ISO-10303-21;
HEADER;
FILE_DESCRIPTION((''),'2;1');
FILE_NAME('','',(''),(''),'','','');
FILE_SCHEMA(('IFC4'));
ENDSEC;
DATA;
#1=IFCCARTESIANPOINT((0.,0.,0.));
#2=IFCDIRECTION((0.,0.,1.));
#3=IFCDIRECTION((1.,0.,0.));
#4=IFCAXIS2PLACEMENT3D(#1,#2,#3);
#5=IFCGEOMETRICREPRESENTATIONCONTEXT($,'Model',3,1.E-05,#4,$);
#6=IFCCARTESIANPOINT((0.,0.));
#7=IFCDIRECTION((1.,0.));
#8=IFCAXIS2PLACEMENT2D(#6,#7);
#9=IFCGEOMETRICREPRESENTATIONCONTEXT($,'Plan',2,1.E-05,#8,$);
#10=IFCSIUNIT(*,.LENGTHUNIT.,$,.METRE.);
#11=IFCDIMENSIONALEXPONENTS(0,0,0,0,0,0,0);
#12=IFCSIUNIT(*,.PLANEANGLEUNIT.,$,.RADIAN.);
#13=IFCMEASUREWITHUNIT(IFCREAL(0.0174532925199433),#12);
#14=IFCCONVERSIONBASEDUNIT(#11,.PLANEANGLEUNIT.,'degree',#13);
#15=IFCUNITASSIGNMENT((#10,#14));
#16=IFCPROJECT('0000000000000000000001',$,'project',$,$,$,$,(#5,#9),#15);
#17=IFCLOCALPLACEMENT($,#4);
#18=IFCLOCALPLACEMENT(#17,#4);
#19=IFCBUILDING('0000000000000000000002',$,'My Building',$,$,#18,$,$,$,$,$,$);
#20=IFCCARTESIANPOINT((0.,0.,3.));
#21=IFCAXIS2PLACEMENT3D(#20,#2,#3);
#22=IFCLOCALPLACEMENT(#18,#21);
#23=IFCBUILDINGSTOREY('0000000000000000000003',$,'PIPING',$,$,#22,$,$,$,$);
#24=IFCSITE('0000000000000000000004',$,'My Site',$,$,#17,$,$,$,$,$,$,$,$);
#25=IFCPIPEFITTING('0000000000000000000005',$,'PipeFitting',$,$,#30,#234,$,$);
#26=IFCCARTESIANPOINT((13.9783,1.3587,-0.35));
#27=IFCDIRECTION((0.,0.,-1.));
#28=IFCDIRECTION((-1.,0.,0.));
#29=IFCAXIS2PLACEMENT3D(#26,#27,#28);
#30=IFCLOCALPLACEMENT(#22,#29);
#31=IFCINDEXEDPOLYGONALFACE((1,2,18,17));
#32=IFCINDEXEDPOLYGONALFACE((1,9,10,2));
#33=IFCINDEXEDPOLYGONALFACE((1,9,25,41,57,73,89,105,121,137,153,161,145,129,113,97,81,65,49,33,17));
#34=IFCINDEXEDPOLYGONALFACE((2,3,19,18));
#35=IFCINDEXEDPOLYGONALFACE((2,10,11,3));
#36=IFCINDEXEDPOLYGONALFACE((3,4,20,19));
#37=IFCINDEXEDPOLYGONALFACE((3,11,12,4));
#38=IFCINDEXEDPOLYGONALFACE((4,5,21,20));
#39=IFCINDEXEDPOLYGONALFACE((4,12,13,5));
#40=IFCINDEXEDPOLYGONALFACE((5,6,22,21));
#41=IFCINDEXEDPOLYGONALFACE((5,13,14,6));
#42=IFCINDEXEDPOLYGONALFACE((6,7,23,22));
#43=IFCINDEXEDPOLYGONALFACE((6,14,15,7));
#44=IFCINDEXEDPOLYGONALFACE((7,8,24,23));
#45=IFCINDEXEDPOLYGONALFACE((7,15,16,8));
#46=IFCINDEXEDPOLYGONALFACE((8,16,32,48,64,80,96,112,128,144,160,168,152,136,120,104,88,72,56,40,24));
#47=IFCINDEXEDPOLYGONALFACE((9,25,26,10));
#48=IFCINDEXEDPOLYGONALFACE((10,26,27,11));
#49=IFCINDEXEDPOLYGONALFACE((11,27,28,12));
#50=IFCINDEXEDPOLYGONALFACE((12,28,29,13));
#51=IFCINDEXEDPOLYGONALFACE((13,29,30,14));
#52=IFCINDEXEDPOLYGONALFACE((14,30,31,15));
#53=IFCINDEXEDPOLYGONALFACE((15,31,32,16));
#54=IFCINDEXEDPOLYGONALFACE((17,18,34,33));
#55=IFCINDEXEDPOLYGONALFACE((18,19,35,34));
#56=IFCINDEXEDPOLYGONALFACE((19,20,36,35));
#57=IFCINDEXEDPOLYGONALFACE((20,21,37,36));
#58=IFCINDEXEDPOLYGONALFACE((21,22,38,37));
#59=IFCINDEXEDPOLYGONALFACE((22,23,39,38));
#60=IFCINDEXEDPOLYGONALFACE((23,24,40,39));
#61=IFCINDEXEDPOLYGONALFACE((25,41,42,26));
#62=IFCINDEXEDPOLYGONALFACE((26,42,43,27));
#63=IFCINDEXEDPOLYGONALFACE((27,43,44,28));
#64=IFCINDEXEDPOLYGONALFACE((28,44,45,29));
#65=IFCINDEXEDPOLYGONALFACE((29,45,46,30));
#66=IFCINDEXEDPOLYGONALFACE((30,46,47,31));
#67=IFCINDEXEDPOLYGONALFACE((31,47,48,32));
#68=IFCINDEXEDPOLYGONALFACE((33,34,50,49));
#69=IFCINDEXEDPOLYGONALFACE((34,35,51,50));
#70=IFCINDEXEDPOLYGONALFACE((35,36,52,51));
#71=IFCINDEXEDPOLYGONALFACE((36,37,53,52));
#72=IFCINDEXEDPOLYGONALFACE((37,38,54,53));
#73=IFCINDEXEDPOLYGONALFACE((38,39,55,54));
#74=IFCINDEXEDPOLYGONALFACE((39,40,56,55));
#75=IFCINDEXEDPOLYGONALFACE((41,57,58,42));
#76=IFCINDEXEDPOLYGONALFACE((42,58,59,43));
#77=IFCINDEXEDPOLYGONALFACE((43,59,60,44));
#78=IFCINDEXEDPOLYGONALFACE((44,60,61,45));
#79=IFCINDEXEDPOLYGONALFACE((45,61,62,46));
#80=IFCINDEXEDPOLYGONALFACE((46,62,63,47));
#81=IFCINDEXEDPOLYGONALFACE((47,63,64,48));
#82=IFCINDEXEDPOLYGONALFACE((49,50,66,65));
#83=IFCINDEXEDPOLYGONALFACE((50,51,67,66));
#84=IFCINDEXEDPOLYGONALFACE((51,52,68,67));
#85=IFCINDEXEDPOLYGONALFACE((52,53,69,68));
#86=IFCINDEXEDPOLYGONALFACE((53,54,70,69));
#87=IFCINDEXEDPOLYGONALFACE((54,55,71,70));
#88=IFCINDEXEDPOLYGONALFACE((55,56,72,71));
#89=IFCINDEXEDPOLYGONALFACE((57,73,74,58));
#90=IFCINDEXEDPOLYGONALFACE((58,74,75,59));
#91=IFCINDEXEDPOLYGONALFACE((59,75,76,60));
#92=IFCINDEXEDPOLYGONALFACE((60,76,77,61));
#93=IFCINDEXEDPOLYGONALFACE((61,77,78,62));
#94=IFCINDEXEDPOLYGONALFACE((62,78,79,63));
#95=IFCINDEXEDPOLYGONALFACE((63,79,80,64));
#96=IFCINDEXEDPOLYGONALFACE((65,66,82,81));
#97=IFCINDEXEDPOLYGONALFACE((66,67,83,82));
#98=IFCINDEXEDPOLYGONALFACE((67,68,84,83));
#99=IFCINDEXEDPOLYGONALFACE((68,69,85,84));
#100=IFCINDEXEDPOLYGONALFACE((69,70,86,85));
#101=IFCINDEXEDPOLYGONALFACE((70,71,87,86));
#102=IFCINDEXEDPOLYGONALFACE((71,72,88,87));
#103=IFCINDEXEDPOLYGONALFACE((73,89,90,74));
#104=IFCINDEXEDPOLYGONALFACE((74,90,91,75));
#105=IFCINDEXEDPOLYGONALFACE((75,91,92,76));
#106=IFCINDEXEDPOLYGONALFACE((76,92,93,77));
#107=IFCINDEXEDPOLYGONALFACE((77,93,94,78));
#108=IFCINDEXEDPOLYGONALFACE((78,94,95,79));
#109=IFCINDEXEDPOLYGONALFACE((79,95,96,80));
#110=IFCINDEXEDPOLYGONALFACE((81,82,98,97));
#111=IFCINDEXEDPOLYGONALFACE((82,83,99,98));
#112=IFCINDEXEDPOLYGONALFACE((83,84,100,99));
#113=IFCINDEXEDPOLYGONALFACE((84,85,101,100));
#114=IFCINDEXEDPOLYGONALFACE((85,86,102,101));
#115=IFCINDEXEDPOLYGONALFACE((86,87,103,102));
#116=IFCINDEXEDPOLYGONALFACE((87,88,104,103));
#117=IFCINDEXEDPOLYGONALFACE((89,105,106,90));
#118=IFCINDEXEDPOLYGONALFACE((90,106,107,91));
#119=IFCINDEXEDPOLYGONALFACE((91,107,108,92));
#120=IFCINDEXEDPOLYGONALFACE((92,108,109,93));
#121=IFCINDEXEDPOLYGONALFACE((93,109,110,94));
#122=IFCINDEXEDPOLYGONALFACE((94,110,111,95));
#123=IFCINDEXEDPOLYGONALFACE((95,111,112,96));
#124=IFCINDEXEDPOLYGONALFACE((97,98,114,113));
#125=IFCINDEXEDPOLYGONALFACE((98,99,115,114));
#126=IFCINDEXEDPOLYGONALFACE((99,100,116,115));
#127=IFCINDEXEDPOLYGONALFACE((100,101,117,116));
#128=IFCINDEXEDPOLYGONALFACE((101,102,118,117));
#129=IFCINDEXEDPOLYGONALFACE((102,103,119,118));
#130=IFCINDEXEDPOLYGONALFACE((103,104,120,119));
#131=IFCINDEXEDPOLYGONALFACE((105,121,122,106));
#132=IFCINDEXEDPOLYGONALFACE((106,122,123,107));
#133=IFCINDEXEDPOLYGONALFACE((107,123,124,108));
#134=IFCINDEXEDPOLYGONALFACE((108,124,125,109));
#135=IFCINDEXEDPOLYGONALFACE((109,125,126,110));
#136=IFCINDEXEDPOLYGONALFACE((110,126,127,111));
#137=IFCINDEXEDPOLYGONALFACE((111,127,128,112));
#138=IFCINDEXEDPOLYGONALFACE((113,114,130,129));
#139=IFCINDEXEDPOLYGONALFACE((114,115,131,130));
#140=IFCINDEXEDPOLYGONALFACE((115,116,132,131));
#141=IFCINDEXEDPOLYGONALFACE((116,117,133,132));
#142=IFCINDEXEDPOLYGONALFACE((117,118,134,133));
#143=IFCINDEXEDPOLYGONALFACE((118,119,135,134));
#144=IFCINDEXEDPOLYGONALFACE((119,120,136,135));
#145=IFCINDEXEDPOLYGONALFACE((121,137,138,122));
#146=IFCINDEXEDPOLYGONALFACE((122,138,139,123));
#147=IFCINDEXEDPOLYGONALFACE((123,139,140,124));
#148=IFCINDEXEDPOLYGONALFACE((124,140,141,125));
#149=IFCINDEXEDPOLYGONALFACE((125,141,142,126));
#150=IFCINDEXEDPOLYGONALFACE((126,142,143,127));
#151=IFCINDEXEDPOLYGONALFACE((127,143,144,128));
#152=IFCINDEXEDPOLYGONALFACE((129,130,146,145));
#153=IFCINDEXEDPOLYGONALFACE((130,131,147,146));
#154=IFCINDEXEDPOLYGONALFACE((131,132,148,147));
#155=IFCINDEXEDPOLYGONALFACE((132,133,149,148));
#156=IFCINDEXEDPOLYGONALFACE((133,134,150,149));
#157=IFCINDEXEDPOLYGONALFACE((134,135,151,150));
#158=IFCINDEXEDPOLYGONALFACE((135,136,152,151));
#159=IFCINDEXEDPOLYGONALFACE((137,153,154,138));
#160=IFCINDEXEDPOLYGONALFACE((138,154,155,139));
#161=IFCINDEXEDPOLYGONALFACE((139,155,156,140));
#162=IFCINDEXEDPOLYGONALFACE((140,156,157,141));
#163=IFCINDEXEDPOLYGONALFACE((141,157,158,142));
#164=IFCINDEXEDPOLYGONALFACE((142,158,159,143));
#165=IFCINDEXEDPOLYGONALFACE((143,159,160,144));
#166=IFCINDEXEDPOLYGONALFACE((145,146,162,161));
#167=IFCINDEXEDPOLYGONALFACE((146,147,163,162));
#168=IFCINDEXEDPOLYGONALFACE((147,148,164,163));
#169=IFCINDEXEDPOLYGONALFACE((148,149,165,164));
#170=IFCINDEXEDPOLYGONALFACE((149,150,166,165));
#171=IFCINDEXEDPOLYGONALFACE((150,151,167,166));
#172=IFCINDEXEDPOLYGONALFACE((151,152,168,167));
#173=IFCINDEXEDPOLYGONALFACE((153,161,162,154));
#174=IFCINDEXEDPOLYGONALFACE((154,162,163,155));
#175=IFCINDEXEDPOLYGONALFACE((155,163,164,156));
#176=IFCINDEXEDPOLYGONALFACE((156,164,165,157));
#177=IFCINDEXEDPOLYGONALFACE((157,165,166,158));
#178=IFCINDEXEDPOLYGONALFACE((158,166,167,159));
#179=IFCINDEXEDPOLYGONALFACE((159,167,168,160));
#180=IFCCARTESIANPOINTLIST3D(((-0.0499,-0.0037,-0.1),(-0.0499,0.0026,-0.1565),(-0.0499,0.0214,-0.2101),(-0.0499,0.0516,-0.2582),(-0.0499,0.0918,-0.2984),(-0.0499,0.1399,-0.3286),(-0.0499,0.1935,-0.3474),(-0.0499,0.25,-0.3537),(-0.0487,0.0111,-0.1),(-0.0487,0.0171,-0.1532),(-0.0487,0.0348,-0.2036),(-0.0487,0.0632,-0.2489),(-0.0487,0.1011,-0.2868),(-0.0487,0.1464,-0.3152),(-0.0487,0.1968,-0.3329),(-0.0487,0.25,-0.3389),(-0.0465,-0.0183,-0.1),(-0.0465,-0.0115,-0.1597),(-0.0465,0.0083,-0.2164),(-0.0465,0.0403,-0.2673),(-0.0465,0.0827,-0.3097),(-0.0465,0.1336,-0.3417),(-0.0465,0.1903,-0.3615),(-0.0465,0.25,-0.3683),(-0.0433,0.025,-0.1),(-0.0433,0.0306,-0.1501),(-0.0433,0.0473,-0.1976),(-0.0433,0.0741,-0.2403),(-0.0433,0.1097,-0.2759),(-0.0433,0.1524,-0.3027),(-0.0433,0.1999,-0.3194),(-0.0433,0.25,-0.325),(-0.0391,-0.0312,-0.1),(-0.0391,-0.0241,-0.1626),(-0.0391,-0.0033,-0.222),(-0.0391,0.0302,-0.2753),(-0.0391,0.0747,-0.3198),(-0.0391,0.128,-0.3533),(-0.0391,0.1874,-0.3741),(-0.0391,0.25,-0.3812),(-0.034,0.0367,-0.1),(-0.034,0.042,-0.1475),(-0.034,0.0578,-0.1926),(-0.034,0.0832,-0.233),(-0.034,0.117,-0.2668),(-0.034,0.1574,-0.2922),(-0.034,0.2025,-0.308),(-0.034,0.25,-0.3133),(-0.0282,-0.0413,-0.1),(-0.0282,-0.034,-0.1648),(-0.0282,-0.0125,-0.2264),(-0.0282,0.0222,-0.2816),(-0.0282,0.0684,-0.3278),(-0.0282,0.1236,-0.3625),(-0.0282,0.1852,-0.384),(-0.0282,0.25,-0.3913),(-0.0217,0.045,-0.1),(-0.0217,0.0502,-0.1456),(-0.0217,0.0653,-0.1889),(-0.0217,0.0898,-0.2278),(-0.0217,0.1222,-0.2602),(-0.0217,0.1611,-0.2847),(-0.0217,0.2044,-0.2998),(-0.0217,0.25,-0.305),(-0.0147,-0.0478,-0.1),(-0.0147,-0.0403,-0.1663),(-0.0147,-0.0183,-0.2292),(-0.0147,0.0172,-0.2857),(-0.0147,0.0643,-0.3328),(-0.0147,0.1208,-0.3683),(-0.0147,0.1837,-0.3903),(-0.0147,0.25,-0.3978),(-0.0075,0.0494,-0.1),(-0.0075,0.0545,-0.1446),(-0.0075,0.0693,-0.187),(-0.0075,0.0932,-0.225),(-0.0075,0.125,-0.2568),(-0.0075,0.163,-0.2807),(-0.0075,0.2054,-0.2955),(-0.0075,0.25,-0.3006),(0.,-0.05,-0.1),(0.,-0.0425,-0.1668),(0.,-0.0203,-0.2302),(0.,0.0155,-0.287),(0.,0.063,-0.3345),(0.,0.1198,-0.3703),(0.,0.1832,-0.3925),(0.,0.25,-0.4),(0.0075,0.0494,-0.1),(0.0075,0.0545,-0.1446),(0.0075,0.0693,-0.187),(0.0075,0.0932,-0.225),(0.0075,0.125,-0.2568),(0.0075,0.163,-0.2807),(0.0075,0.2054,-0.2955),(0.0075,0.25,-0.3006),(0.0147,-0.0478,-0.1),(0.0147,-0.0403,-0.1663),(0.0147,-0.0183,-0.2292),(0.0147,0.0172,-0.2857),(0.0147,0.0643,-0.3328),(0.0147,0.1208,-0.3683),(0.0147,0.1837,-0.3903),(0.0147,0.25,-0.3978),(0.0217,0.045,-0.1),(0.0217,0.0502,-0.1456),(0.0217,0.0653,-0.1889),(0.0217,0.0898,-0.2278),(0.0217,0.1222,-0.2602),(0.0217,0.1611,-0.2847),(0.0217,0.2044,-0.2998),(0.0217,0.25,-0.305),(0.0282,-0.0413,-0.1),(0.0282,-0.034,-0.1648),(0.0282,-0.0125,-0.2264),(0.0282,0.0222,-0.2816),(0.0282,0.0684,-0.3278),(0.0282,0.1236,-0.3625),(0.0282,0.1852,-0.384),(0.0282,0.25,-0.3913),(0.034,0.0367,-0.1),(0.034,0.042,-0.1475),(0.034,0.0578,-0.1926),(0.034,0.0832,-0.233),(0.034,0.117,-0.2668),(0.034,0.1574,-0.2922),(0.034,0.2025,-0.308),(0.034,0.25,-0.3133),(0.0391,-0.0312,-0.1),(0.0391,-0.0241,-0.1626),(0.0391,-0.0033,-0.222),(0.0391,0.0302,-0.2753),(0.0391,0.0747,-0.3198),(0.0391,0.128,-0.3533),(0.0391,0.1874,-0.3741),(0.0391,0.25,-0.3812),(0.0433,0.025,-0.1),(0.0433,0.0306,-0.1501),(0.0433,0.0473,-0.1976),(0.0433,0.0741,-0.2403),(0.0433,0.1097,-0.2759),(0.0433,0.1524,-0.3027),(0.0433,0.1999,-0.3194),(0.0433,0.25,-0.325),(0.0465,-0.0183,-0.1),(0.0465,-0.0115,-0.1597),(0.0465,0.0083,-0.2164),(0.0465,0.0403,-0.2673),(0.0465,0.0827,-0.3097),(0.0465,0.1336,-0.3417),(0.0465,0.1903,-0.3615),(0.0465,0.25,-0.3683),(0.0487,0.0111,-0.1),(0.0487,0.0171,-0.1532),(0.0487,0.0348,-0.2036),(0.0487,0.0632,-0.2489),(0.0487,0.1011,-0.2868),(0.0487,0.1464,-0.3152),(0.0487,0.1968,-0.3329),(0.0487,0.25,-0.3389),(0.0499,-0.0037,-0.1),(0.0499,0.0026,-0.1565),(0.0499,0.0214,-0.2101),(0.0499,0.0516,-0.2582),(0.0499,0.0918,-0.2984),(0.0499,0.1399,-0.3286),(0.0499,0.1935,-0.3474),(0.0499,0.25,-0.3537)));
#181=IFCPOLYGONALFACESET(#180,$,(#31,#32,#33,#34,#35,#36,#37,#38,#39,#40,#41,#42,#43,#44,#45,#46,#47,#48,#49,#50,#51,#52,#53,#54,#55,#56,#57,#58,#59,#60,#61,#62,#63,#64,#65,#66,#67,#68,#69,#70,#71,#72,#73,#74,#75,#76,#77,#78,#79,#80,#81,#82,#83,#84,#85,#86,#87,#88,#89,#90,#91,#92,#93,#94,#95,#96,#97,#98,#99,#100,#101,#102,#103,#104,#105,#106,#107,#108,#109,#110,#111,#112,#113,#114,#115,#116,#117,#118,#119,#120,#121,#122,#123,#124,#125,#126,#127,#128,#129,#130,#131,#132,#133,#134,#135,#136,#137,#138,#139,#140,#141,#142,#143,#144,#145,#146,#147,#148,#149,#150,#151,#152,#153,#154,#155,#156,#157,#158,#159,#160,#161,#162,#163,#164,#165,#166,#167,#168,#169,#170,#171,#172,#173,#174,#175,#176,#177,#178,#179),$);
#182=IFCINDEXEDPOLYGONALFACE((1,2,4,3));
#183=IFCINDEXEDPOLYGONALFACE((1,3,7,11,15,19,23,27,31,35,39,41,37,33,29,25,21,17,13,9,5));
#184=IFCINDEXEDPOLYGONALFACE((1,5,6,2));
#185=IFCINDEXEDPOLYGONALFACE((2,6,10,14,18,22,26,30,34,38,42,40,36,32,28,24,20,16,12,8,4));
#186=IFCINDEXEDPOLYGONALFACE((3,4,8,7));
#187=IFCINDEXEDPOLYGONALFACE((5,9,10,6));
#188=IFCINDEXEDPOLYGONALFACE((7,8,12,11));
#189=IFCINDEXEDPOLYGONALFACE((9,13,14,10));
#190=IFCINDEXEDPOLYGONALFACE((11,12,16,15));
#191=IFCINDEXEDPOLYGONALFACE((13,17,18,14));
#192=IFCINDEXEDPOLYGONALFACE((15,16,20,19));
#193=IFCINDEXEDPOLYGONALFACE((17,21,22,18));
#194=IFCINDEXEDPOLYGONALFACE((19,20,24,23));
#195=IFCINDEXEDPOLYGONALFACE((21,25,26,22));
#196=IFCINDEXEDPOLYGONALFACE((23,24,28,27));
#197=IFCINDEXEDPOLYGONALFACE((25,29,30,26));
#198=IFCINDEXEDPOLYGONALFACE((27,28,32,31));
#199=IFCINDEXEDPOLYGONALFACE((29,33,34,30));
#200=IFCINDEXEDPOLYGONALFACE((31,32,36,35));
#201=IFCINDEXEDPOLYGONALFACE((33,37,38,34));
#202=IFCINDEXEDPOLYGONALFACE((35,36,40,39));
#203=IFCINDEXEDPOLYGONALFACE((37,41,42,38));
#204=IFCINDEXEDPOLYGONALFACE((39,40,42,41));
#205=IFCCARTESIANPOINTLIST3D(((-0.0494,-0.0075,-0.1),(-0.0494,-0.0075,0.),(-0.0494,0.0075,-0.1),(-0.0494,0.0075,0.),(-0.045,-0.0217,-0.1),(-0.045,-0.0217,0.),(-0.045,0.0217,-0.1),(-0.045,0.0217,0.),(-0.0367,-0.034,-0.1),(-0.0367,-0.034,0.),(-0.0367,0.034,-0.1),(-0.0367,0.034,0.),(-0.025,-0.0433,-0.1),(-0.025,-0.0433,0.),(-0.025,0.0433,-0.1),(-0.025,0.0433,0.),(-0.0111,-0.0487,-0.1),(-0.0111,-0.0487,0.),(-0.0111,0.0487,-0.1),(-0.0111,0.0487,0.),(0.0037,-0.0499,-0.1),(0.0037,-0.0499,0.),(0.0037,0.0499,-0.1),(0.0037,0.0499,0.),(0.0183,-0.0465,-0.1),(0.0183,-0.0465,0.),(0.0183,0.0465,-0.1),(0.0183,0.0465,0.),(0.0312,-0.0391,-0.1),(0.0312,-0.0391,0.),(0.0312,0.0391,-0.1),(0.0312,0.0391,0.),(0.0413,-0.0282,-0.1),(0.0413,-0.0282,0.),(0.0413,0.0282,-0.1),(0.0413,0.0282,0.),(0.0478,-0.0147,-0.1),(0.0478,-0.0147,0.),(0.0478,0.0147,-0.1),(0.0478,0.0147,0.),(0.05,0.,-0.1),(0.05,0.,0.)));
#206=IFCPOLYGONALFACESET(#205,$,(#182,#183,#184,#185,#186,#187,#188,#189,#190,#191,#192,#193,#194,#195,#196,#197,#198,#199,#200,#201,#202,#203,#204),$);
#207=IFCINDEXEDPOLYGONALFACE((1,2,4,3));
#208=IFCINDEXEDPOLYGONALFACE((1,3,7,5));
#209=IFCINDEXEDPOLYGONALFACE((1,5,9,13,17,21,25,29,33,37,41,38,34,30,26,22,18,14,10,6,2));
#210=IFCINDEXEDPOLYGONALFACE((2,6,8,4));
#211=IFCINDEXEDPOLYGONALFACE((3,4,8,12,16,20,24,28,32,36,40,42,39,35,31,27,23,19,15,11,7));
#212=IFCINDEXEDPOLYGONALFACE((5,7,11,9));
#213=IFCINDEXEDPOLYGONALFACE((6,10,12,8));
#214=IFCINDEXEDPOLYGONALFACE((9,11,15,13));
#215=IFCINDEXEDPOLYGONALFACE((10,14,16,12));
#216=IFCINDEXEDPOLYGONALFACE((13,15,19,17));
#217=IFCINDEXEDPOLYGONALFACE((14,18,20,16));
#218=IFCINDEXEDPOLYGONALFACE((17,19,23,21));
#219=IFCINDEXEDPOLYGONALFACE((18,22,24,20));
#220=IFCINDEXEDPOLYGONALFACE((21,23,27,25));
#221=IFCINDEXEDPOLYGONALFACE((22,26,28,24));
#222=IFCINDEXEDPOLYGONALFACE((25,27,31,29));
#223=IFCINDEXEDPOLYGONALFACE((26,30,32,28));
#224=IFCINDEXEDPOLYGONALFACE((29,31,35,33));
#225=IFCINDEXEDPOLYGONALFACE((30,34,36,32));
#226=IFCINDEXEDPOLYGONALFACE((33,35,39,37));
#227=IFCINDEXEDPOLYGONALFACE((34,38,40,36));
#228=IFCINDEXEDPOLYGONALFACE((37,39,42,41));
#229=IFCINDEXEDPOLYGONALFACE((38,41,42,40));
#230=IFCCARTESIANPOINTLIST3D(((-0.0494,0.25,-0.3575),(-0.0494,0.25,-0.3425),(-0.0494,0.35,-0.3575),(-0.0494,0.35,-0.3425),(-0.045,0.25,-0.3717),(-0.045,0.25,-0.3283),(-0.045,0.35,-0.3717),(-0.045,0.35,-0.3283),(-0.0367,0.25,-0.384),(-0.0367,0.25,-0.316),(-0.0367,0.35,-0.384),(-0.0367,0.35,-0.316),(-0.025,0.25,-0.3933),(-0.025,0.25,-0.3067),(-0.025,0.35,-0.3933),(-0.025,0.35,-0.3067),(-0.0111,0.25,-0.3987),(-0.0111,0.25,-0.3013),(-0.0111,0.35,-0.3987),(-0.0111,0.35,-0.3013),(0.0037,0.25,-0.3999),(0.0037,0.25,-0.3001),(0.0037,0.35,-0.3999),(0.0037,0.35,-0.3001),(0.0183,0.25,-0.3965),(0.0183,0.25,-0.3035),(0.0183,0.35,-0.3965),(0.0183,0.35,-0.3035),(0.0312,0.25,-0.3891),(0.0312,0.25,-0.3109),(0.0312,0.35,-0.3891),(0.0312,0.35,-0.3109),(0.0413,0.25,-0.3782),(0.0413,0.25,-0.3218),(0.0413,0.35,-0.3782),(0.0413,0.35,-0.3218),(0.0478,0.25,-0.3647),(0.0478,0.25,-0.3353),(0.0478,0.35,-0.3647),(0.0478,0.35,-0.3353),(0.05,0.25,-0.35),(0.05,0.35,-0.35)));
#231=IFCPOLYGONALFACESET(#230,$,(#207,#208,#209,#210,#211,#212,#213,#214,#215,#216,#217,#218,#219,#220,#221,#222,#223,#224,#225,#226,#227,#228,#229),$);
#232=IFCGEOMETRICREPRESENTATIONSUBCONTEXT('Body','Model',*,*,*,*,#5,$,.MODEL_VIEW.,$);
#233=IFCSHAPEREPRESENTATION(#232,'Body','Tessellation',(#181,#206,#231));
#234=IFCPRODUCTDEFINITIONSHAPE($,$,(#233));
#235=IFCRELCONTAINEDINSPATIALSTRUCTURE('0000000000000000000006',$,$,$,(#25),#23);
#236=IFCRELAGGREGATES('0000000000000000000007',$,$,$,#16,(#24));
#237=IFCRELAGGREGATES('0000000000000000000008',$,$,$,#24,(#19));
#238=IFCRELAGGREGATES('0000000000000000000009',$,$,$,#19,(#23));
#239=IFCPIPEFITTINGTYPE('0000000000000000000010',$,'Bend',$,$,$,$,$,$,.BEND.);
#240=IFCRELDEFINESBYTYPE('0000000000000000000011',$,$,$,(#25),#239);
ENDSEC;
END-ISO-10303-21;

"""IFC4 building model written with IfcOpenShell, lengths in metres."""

from ifc_helpers import new_model, entity, si_unit, converted_unit, frame, origin_with_axes, origin_2d_with_axis, place, context, subcontext, project, spatial, line, indexed_curve, circle, outline, extrude, source, transform, mapped, type_object, type_shapes, element, save


model = new_model("IFC4")

# Units and contexts
model_context = context("Model", 3, precision=1e-05, world=origin_with_axes())
plan_context = context("Plan", 2, precision=1e-05, world=origin_2d_with_axis())
body_context = subcontext(model_context, "Body", "Model", "MODEL_VIEW")
ifc_project = project(units=[si_unit("LENGTHUNIT", "METRE"), converted_unit("PLANEANGLEUNIT", "degree", entity("IfcReal", 0.0174532925199433), si_unit("PLANEANGLEUNIT", "RADIAN"), dimensions=[0, 0, 0, 0, 0, 0, 0])], contexts=[model_context, plan_context])

# Site, building, storey
site_placement = place(None, origin_with_axes())
site = spatial("IfcSite", under=ifc_project, at=site_placement, Name="My Site")
building_placement = place(site_placement, origin_with_axes())
building = spatial("IfcBuilding", under=site, at=building_placement, Name="My Building")
storey_placement = place(building_placement, frame((0.0, 0.0, 3.0), z_axis=(0.0, 0.0, 1.0), x_axis=(1.0, 0.0, 0.0)))
storey = spatial("IfcBuildingStorey", under=building, at=storey_placement, Name="PIPING")

# Shared definitions
pipe_fitting_type = type_object("IfcPipeFittingType", Name="Bend", PredefinedType="BEND")
shared_shape = source(origin_with_axes(), body_context, "Body", "SolidModel", [
    entity("IfcSweptDiskSolid", entity("IfcIndexedPolyCurve", entity("IfcCartesianPointList3D", [[0.0, 0.0, -0.1], [0.0, 0.0732, -0.2768], [0.0, 0.25, -0.35]]), [entity("IfcArcIndex", [1, 2, 3])]), 0.05),
    extrude(circle(Radius=0.05), origin_with_axes(), (0.0, 0.0, -1.0), 0.1),
    extrude(circle(Radius=0.05), frame((0.0, 0.25, -0.35), z_axis=(0.0, 1.0, 0.0), x_axis=(1.0, 0.0, 0.0)), (0.0, 0.0, 1.0), 0.1),
])
type_shapes(pipe_fitting_type, [shared_shape])

# Pipe fitting, opening
pipe_fitting_1_placement = place(storey_placement, frame((13.9783, 1.3587, -0.35), z_axis=(0.0, 0.0, -1.0), x_axis=(-1.0, 0.0, 0.0)))
pipe_fitting_1 = element("IfcPipeFitting", 1, at=pipe_fitting_1_placement, inside=storey, type_object=pipe_fitting_type, Name="PipeFitting", context=body_context, shape_type="MappedRepresentation", body=[
    mapped(shared_shape, transform((0.0, 0.0, 0.0), x_axis=(1.0, 0.0, 0.0), y_axis=(0.0, 1.0, 0.0), z_axis=(0.0, 0.0, 1.0), scale=1.0)),
])
opening_1_placement = place(pipe_fitting_1_placement, frame((1.768, -1.3587, 2.65), z_axis=(0.0, 0.0, -1.0), x_axis=(-1.0, 0.0, 0.0)))
element("IfcOpeningElement", 2, at=opening_1_placement, cuts=pipe_fitting_1, PredefinedType="OPENING", context=body_context, shape_type="SweptSolid", body=[
    extrude(outline(indexed_curve([(0.0, 0.0), (0.5, 0.0), (0.5, 0.5), (0.0, 0.5)], segments=[line(1, 2, 3, 4, 1)])), origin_with_axes(), (0.0, 0.0, 1.0), 0.5),
])

save(model, "model.ifc")
